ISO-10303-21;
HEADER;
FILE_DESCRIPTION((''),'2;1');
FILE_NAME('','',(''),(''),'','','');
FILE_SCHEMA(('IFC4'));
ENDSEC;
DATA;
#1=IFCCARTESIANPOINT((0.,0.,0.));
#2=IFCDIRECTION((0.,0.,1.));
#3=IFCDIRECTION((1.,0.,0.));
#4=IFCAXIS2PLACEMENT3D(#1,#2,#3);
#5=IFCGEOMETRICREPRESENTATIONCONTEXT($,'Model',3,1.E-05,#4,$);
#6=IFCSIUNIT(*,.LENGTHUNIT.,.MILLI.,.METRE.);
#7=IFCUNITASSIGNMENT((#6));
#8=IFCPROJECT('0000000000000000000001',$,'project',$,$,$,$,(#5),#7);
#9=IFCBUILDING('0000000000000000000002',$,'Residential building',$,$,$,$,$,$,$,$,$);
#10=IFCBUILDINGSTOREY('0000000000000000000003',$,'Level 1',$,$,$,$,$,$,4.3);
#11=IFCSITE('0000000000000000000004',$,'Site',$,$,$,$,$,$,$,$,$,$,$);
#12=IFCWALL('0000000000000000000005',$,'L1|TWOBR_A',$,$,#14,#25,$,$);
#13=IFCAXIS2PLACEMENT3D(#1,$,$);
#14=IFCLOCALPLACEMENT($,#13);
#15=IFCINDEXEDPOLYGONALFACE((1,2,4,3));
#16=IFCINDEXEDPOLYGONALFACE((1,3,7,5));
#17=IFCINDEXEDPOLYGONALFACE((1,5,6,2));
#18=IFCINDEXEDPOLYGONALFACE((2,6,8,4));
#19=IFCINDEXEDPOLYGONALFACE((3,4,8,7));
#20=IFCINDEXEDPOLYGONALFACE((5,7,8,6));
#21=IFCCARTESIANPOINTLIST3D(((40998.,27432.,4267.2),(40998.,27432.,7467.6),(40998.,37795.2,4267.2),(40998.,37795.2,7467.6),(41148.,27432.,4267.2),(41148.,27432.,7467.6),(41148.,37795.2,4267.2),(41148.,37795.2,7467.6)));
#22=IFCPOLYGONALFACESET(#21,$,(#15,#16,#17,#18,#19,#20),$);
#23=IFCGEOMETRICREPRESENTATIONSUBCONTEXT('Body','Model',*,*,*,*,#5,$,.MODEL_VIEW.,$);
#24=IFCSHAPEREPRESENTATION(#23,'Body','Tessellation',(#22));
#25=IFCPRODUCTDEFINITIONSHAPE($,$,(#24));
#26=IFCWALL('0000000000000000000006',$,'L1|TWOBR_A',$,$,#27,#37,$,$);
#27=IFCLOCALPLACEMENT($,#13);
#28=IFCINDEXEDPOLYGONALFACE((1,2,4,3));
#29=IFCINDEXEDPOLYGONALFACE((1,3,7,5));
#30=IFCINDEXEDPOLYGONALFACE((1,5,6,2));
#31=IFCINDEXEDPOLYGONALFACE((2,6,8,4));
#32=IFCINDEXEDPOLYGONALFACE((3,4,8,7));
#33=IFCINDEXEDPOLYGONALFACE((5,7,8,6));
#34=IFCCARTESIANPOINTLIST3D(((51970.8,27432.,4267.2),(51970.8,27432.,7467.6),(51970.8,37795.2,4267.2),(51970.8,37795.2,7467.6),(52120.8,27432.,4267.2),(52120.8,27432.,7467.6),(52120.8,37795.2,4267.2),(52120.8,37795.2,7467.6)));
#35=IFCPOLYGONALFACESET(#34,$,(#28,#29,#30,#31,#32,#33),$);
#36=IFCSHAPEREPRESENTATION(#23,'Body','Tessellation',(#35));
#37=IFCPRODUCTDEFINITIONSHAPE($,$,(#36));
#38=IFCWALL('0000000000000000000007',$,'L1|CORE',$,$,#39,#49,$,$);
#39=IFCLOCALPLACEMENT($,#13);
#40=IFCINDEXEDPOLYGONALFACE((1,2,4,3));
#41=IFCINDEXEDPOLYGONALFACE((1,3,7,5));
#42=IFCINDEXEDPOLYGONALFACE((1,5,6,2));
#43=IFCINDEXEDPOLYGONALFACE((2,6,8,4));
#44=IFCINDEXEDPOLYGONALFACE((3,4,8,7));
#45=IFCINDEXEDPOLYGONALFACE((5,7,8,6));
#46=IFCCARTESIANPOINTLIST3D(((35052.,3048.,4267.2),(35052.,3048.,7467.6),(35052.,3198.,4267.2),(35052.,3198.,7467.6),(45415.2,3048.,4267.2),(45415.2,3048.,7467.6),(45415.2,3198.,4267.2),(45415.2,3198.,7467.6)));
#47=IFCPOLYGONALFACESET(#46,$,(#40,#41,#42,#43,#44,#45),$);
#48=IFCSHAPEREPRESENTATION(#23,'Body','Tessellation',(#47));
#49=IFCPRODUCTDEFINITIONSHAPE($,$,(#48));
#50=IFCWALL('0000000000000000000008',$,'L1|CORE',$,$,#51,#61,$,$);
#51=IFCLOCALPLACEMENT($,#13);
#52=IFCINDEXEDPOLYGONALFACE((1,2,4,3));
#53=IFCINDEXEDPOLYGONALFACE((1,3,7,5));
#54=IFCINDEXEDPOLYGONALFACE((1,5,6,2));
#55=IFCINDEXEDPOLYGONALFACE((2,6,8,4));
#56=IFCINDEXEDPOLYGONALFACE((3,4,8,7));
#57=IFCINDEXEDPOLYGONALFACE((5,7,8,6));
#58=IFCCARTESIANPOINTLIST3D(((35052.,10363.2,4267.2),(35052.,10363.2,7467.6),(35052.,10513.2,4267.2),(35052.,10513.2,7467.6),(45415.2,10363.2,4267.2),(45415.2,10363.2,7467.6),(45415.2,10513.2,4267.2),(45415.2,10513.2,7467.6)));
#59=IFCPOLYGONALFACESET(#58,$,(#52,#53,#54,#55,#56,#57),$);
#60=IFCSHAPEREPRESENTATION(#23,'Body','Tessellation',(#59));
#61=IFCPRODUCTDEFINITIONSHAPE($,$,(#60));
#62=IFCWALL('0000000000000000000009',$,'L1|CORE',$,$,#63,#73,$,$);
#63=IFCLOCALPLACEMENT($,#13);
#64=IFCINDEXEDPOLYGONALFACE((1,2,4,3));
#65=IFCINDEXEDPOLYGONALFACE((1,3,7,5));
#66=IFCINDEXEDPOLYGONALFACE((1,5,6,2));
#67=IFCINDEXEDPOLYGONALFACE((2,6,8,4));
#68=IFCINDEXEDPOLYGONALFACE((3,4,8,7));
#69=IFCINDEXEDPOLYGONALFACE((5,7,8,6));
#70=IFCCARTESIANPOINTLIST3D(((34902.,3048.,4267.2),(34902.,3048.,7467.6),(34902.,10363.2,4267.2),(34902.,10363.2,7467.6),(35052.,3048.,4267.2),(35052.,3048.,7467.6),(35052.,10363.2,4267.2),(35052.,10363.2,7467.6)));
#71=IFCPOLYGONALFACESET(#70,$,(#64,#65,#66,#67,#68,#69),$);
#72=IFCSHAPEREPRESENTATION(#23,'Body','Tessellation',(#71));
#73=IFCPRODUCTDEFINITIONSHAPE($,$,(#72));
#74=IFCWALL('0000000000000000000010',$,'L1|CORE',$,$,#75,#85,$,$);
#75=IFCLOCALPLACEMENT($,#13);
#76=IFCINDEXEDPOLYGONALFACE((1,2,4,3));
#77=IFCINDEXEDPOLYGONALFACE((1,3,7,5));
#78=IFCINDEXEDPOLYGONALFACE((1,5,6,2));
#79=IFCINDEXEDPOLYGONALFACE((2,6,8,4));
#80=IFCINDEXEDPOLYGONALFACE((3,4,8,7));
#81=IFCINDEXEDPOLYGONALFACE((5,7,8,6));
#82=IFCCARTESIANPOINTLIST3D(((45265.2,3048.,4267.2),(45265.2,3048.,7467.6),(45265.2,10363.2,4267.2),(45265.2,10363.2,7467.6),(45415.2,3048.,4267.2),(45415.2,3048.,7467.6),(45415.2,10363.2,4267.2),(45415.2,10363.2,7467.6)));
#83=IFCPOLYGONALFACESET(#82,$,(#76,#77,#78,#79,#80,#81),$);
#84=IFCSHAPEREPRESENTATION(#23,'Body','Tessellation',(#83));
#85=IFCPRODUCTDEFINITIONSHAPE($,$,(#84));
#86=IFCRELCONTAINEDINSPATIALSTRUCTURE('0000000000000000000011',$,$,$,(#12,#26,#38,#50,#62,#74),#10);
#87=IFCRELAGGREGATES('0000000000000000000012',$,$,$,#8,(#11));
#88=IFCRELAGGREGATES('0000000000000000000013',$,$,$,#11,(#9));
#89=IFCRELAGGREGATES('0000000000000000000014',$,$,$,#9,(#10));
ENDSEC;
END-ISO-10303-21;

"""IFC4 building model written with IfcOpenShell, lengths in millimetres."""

from ifc_helpers import new_model, si_unit, frame, origin_with_axes, place, context, subcontext, project, spatial, indexed_curve, outline, extrude, element, save


model = new_model("IFC4")

# Units and contexts
model_context = context("Model", 3, precision=1e-05, world=origin_with_axes())
body_context = subcontext(model_context, "Body", "Model", "MODEL_VIEW")
ifc_project = project(units=[si_unit("LENGTHUNIT", "METRE", prefix="MILLI")], contexts=[model_context])

# Site, building, storey
site = spatial("IfcSite", under=ifc_project, Name="Site")
building = spatial("IfcBuilding", under=site, Name="Residential building")
storey = spatial("IfcBuildingStorey", under=building, Name="Level 1", Elevation=4.3)

# Walls
for number, where, z_axis, x_axis, name in (
    (1, (41148.0, 27432.0, 4267.2), (0.0, 0.0, 1.0), (0.0, 1.0, 0.0), "L1|TWOBR_A"),
    (2, (52120.8, 27432.0, 4267.2), (0.0, 0.0, 1.0), (0.0, 1.0, 0.0), "L1|TWOBR_A"),
    (3, (35052.0, 3048.0, 4267.2), (0.0, 0.0, 1.0), (1.0, 0.0, 0.0), "L1|CORE"),
    (4, (35052.0, 10363.2, 4267.2), (0.0, 0.0, 1.0), (1.0, 0.0, 0.0), "L1|CORE"),
):
    element("IfcWall", number, at=place(None, frame(where, z_axis=z_axis, x_axis=x_axis)), inside=storey, Name=name, context=body_context, shape_type="SweptSolid", body=[
        extrude(outline(indexed_curve([(0.0, 0.0), (0.0, 150.0), (10363.2, 150.0), (10363.2, 0.0), (0.0, 0.0)], self_intersect=False)), origin_with_axes(), (0.0, 0.0, 1.0), 3200.4),
    ])
for number, where, z_axis, x_axis, name in (
    (5, (35052.0, 3048.0, 4267.2), (0.0, 0.0, 1.0), (0.0, 1.0, 0.0), "L1|CORE"),
    (6, (45415.2, 3048.0, 4267.2), (0.0, 0.0, 1.0), (0.0, 1.0, 0.0), "L1|CORE"),
):
    element("IfcWall", number, at=place(None, frame(where, z_axis=z_axis, x_axis=x_axis)), inside=storey, Name=name, context=body_context, shape_type="SweptSolid", body=[
        extrude(outline(indexed_curve([(0.0, 0.0), (0.0, 150.0), (7315.2, 150.0), (7315.2, 0.0), (0.0, 0.0)], self_intersect=False)), origin_with_axes(), (0.0, 0.0, 1.0), 3200.4),
    ])

save(model, "model.ifc")
